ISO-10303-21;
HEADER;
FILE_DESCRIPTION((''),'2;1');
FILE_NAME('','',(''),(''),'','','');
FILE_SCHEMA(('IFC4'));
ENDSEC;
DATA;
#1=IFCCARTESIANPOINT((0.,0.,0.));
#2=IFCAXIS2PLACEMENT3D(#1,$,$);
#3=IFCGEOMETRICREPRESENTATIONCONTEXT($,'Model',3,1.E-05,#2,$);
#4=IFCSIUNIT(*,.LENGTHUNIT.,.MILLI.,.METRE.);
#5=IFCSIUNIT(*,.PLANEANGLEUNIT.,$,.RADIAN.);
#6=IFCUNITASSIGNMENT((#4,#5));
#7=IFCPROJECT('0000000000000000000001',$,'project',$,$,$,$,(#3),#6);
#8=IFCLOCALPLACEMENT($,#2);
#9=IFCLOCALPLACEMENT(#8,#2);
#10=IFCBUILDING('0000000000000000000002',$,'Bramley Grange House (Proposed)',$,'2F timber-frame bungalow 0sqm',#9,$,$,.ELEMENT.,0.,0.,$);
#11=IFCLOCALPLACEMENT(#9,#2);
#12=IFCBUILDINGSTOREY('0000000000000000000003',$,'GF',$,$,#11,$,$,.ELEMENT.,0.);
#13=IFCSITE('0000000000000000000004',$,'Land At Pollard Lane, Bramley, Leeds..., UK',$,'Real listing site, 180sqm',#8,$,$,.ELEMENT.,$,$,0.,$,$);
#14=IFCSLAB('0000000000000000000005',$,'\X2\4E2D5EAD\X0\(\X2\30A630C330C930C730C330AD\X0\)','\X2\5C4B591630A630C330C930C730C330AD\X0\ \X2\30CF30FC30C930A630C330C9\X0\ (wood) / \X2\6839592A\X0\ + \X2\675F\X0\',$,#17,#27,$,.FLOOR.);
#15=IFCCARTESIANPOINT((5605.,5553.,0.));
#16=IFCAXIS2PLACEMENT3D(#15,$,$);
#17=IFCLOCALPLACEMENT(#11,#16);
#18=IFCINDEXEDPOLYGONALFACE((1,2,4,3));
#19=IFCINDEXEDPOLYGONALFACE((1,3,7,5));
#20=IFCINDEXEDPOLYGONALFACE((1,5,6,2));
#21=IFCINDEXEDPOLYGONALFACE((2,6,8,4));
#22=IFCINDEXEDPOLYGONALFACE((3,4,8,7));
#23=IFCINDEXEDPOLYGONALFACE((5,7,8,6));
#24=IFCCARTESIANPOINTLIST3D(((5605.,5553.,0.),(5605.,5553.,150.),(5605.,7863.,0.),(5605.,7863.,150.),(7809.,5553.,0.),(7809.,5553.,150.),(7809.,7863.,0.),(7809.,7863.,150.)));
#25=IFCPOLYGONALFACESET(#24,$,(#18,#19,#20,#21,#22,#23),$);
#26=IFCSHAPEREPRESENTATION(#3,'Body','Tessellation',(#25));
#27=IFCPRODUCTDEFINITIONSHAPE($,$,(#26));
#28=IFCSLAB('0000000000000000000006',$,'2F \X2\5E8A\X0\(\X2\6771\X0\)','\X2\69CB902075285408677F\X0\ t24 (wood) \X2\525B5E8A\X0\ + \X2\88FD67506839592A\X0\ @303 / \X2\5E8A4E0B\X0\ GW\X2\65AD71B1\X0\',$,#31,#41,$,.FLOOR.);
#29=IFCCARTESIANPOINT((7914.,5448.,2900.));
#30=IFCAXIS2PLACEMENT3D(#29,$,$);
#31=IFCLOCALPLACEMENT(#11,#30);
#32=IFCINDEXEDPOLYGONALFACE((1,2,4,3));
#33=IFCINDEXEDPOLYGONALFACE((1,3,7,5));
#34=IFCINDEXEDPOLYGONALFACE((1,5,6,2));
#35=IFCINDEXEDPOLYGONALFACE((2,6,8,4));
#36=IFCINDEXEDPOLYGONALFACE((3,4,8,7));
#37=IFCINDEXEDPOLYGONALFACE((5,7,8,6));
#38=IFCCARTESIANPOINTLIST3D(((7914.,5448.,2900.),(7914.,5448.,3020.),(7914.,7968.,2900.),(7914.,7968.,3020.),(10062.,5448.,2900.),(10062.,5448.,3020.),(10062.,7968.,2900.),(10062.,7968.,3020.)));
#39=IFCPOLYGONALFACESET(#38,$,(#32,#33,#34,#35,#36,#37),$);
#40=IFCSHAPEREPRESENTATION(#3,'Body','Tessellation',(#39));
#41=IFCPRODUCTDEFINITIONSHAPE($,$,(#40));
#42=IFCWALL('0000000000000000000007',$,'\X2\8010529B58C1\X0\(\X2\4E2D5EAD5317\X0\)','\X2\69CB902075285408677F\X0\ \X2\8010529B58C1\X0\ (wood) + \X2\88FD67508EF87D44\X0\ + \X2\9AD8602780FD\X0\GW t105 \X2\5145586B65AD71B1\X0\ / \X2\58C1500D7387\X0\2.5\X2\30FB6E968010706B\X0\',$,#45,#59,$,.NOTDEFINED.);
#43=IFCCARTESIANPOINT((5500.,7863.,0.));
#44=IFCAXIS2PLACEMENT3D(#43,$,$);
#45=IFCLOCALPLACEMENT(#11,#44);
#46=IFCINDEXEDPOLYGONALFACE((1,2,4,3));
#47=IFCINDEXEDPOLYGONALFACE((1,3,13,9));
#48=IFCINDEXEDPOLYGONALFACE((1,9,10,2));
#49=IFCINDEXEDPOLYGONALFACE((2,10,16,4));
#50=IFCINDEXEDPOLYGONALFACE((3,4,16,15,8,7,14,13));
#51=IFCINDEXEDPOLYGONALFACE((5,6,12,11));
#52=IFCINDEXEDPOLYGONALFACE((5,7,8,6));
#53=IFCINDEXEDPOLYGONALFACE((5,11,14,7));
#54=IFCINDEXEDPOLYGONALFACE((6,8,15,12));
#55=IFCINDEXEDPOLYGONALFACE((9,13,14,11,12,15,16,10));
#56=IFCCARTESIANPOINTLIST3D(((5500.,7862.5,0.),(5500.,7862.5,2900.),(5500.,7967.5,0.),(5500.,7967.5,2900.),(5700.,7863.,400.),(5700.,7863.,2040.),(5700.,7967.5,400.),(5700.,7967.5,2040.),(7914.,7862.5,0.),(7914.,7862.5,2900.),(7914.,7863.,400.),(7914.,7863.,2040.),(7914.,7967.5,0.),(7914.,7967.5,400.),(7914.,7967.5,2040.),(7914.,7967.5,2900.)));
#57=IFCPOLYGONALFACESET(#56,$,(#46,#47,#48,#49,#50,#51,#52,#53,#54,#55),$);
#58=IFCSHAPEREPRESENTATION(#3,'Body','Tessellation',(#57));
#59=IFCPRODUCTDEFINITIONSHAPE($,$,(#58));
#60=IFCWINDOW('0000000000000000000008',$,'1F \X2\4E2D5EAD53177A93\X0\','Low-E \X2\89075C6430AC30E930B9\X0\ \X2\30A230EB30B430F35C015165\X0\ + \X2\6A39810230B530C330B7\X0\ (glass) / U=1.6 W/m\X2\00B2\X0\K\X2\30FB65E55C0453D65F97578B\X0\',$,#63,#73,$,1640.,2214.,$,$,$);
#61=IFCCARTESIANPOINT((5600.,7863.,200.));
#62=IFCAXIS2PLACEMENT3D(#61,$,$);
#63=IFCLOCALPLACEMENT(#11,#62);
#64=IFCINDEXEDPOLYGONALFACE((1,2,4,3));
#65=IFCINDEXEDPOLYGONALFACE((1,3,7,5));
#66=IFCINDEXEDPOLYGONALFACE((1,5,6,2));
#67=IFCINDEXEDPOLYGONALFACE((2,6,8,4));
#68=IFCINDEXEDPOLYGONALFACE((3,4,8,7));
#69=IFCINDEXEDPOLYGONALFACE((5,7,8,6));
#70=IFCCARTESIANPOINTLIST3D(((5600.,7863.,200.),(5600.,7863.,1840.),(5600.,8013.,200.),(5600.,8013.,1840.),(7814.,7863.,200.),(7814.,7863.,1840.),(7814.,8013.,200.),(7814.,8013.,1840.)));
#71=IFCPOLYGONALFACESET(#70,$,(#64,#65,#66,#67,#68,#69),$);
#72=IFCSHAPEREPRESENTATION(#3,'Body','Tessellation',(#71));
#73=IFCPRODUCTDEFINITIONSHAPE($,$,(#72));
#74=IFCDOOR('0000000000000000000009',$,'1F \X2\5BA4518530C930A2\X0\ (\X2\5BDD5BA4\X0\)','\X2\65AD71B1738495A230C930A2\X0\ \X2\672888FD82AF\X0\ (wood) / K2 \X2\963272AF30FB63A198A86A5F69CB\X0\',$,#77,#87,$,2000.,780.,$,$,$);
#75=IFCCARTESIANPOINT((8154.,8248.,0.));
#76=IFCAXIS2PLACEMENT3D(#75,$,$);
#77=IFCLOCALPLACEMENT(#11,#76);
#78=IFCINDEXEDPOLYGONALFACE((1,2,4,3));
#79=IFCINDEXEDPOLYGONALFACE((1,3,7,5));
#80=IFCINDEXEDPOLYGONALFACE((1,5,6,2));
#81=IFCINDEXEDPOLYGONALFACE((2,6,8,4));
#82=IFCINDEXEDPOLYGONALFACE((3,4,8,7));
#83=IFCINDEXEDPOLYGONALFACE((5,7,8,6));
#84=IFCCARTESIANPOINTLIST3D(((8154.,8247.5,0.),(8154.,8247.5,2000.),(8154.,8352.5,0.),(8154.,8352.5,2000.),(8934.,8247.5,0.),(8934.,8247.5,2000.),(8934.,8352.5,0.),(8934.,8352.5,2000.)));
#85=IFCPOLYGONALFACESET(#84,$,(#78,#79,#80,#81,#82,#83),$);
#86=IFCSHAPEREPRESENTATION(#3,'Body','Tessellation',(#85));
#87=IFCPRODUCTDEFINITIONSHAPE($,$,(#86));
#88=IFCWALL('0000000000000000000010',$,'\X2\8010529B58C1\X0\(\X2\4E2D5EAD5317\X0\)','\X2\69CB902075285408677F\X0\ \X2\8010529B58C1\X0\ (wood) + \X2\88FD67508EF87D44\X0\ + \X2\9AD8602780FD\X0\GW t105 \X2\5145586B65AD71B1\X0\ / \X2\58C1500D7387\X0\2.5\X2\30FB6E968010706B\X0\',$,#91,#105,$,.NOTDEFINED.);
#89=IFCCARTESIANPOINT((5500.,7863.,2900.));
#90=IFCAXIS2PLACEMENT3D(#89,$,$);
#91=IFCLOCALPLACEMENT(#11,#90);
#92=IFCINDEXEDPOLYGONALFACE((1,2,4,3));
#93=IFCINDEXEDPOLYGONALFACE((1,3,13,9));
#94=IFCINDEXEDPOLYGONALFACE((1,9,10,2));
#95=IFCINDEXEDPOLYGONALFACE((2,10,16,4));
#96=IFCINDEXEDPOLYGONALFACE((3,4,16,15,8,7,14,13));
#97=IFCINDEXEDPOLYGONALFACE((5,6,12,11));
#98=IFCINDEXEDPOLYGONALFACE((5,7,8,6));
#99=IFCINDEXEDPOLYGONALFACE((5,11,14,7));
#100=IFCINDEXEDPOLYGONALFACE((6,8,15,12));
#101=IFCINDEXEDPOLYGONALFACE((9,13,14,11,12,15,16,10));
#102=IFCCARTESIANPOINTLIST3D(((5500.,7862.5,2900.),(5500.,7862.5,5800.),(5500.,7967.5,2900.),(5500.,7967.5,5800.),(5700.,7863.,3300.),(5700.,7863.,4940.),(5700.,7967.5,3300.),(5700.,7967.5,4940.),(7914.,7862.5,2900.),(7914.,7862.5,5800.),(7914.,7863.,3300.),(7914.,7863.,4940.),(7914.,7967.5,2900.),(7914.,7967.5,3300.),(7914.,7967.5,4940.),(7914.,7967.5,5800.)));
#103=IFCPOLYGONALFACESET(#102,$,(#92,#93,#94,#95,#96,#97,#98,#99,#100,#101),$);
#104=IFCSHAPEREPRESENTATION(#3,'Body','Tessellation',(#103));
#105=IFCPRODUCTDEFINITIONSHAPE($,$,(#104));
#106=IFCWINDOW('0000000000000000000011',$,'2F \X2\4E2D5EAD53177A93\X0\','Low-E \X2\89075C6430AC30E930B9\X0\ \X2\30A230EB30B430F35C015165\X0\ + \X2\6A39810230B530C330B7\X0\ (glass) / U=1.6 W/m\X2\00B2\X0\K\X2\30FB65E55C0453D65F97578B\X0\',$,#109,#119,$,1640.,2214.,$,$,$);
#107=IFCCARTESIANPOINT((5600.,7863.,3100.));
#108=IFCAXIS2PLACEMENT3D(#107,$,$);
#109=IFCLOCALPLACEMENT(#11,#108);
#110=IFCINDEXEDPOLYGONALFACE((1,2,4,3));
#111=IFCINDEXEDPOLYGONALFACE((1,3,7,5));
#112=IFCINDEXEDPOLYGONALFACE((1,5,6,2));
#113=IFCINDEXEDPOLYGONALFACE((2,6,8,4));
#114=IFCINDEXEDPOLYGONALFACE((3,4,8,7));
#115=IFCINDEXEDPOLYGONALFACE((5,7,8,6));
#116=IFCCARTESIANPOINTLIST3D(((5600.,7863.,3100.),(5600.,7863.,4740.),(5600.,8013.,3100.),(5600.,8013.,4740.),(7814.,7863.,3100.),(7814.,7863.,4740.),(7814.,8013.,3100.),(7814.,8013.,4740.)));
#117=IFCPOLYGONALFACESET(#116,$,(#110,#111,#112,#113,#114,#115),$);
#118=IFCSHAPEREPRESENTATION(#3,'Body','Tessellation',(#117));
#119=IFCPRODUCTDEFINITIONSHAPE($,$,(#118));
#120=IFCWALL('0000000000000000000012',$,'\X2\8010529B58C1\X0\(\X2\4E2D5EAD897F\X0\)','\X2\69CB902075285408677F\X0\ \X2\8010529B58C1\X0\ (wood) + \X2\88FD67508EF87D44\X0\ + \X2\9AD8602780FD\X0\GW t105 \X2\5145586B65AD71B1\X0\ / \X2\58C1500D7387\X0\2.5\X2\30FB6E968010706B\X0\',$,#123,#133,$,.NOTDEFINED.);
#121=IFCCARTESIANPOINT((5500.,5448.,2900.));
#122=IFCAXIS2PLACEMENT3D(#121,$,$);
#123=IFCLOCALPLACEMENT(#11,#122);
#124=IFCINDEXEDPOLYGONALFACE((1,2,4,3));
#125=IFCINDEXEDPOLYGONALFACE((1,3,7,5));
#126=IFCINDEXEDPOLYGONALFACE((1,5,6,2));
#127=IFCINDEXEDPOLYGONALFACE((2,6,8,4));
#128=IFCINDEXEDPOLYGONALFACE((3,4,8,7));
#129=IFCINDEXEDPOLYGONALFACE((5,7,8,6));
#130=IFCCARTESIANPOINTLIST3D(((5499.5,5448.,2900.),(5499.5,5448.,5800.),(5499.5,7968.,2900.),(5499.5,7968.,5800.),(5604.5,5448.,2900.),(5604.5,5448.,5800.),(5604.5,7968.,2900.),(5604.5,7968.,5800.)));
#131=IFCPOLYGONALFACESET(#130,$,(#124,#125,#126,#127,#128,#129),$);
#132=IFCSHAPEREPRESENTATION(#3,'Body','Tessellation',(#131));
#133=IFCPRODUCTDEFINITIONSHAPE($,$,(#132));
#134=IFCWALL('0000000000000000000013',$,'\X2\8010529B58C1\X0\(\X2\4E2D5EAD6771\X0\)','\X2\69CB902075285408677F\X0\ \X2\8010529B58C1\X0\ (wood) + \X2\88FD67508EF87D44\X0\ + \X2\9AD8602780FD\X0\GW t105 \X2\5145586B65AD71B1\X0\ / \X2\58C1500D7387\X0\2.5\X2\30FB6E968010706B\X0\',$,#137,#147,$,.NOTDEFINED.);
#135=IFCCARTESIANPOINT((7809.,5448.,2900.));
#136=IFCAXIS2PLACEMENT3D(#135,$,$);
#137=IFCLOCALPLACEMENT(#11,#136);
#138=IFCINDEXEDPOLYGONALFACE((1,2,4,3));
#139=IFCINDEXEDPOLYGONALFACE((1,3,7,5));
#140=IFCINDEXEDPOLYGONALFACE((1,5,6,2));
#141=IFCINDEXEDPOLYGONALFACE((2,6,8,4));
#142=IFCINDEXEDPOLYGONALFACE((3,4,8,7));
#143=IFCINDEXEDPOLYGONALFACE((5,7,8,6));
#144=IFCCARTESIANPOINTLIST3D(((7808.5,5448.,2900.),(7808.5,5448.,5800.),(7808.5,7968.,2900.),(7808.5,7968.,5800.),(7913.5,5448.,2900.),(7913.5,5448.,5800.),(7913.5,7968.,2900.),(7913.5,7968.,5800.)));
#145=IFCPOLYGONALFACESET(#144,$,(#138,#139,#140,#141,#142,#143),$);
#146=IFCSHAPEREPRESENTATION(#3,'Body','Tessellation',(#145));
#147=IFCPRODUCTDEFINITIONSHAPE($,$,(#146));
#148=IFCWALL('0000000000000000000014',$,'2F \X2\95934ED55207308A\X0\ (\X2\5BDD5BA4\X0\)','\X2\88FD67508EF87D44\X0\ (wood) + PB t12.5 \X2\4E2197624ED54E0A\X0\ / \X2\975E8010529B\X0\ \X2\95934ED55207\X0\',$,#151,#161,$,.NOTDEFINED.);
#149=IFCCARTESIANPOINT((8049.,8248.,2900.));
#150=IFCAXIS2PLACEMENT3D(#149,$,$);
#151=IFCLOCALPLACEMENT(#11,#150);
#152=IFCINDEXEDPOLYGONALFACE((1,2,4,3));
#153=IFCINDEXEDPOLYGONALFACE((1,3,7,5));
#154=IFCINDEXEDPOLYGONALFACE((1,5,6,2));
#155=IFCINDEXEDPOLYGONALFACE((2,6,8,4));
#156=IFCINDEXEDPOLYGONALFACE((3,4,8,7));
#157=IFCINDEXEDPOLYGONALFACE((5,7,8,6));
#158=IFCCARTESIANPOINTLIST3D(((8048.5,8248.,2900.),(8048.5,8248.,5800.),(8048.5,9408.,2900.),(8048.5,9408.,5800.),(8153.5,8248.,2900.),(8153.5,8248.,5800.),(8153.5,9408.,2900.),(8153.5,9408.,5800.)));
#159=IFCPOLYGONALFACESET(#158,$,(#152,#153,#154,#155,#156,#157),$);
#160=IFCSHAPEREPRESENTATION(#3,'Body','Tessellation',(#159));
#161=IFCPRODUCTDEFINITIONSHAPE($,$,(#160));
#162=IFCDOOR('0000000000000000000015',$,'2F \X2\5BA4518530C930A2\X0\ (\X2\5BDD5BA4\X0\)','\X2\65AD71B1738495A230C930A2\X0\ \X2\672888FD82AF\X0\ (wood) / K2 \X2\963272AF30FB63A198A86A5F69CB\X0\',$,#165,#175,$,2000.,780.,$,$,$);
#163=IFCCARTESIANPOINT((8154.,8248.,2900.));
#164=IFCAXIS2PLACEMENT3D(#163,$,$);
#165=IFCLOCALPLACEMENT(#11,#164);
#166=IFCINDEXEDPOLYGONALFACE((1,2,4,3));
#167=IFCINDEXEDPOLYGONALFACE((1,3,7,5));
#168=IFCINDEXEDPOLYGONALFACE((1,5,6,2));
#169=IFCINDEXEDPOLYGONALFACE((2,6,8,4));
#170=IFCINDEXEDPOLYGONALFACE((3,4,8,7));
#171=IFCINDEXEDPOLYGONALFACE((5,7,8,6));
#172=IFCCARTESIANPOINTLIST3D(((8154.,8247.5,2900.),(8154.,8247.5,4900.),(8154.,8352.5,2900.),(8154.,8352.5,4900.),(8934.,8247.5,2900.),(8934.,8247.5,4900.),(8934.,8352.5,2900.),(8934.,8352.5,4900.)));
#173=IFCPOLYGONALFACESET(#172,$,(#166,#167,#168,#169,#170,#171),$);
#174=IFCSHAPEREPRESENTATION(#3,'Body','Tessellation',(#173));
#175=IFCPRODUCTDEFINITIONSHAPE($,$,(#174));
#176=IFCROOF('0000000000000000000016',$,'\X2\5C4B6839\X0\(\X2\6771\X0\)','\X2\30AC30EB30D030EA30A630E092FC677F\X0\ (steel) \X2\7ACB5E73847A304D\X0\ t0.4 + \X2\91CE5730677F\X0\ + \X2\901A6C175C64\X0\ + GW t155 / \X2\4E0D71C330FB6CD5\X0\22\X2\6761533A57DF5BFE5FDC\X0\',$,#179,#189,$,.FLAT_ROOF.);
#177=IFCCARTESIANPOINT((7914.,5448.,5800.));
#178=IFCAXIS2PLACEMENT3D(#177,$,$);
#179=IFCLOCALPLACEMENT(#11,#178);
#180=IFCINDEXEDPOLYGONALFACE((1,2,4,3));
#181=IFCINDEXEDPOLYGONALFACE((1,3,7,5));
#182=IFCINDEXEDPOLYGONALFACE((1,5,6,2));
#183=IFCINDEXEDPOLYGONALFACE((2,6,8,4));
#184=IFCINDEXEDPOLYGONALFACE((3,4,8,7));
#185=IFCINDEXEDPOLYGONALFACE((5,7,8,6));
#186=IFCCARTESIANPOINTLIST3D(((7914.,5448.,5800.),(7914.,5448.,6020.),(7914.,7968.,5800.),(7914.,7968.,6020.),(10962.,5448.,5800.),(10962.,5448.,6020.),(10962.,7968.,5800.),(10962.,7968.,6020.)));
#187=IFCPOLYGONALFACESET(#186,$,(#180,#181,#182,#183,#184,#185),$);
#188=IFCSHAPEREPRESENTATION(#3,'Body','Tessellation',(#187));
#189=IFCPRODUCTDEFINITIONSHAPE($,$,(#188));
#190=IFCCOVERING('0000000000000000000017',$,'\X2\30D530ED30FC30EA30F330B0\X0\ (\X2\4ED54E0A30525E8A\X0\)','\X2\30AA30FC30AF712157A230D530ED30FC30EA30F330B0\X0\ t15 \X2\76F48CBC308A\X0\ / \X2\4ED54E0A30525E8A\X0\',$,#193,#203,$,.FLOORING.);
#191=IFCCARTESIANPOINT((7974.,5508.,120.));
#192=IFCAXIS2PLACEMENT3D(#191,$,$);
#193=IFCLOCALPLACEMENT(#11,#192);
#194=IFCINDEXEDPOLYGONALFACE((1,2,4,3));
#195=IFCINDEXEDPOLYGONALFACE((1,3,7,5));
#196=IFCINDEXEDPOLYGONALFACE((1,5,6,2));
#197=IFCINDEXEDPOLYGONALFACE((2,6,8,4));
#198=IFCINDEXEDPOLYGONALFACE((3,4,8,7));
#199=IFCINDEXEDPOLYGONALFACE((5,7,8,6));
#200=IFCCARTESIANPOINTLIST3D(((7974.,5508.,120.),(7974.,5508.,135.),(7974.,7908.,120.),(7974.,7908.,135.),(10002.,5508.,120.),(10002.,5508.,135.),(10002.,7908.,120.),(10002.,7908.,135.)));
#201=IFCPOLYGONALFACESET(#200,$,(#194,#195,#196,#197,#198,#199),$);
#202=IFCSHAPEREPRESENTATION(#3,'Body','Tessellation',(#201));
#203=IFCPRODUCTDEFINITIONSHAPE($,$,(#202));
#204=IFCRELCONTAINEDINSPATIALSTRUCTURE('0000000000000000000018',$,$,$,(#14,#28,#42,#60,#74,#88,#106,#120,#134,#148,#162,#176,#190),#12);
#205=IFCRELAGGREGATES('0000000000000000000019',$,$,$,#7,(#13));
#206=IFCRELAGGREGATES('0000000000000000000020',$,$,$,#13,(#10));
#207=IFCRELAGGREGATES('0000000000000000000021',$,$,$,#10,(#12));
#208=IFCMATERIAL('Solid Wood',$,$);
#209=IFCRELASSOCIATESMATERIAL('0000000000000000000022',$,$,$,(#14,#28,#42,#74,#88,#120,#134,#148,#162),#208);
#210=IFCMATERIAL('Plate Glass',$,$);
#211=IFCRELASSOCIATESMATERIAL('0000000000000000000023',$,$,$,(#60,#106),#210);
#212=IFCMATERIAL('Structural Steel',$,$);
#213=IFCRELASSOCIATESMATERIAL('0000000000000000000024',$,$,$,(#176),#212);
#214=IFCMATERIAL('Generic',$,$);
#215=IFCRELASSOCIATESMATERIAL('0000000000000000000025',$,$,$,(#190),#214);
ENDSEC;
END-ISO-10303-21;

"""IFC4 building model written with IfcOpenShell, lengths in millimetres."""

from ifc_helpers import new_model, si_unit, frame, frame_2d, origin, place, context, project, spatial, rectangle, extrude, material, element, fill, save


model = new_model("IFC4")

# Units and contexts
model_context = context("Model", 3, precision=1e-05, world=origin())
ifc_project = project(units=[si_unit("LENGTHUNIT", "METRE", prefix="MILLI"), si_unit("PLANEANGLEUNIT", "RADIAN")], contexts=[model_context])

# Site, building, storey
site_placement = place(None, origin())
site = spatial("IfcSite", under=ifc_project, at=site_placement, Name="Land At Pollard Lane, Bramley, Leeds..., UK", ObjectType="Real listing site, 180sqm", CompositionType="ELEMENT", RefElevation=0.0)
building_placement = place(site_placement, origin())
building = spatial("IfcBuilding", under=site, at=building_placement, Name="Bramley Grange House (Proposed)", ObjectType="2F timber-frame bungalow 0sqm", CompositionType="ELEMENT", ElevationOfRefHeight=0.0, ElevationOfTerrain=0.0)
storey_placement = place(building_placement, origin())
storey = spatial("IfcBuildingStorey", under=building, at=storey_placement, Name="GF", CompositionType="ELEMENT", Elevation=0.0)

# Slabs
ifc_material_1 = material(Name="Solid Wood")
slab_1_placement = place(storey_placement, frame((5605.0, 5553.0, 0.0)))
element("IfcSlab", 1, at=slab_1_placement, inside=storey, material=ifc_material_1, Name="中庭(ウッドデッキ)", Description="屋外ウッドデッキ ハードウッド (wood) / 根太 + 束", PredefinedType="FLOOR", context=model_context, shape_type="SweptSolid", body=[
    extrude(rectangle(XDim=2204.0, YDim=2310.0, at=frame_2d((1102.0, 1155.0))), frame((5605.0, 5553.0, 0.0)), (0.0, 0.0, 1.0), 150.0),
])
slab_2_placement = place(storey_placement, frame((7914.0, 5448.0, 2900.0)))
element("IfcSlab", 2, at=slab_2_placement, inside=storey, material=ifc_material_1, Name="2F 床(東)", Description="構造用合板 t24 (wood) 剛床 + 製材根太 @303 / 床下 GW断熱", PredefinedType="FLOOR", context=model_context, shape_type="SweptSolid", body=[
    extrude(rectangle(XDim=2148.0, YDim=2520.0, at=frame_2d((1074.0, 1260.0))), frame((7914.0, 5448.0, 2900.0)), (0.0, 0.0, 1.0), 120.0),
])

# Wall, opening, window
wall_1_placement = place(storey_placement, frame((5500.0, 7863.0, 0.0)))
wall_1 = element("IfcWall", 3, at=wall_1_placement, inside=storey, material=ifc_material_1, Name="耐力壁(中庭北)", Description="構造用合板 耐力壁 (wood) + 製材軸組 + 高性能GW t105 充填断熱 / 壁倍率2.5・準耐火", PredefinedType="NOTDEFINED", context=model_context, shape_type="SweptSolid", body=[
    extrude(rectangle(XDim=2414.0, YDim=105.0, at=frame_2d((1207.0, 52.0))), frame((5500.0, 7863.0, 0.0)), (0.0, 0.0, 1.0), 2900.0),
])
opening_1_placement = place(storey_placement, frame((5600.0, 7863.0, 200.0)))
opening_1 = element("IfcOpeningElement", 4, at=opening_1_placement, cuts=wall_1, PredefinedType="NOTDEFINED", context=model_context, shape_type="SweptSolid", body=[
    extrude(rectangle(XDim=2214.0, YDim=150.0, at=frame_2d((1107.0, 75.0))), frame((5600.0, 7863.0, 200.0)), (0.0, 0.0, 1.0), 1640.0),
])
ifc_material_2 = material(Name="Plate Glass")
window_1_placement = place(storey_placement, frame((5600.0, 7863.0, 200.0)))
window_1 = element("IfcWindow", 5, at=window_1_placement, inside=storey, material=ifc_material_2, Name="1F 中庭北窓", Description="Low-E 複層ガラス アルゴン封入 + 樹脂サッシ (glass) / U=1.6 W/m²K・日射取得型", OverallHeight=1640.0, OverallWidth=2214.0, context=model_context, shape_type="SweptSolid", body=[
    extrude(rectangle(XDim=2214.0, YDim=150.0, at=frame_2d((1107.0, 75.0))), frame((5600.0, 7863.0, 200.0)), (0.0, 0.0, 1.0), 1640.0),
])
fill(opening_1, window_1)

# Door
door_1_placement = place(storey_placement, frame((8154.0, 8248.0, 0.0)))
element("IfcDoor", 6, at=door_1_placement, inside=storey, material=ifc_material_1, Name="1F 室内ドア (寝室)", Description="断熱玄関ドア 木製芯 (wood) / K2 防犯・採風機構", OverallHeight=2000.0, OverallWidth=780.0, context=model_context, shape_type="SweptSolid", body=[
    extrude(rectangle(XDim=780.0, YDim=105.0, at=frame_2d((390.0, 52.0))), frame((8154.0, 8248.0, 0.0)), (0.0, 0.0, 1.0), 2000.0),
])

# Wall, opening, window
wall_2_placement = place(storey_placement, frame((5500.0, 7863.0, 2900.0)))
wall_2 = element("IfcWall", 7, at=wall_2_placement, inside=storey, material=ifc_material_1, Name="耐力壁(中庭北)", Description="構造用合板 耐力壁 (wood) + 製材軸組 + 高性能GW t105 充填断熱 / 壁倍率2.5・準耐火", PredefinedType="NOTDEFINED", context=model_context, shape_type="SweptSolid", body=[
    extrude(rectangle(XDim=2414.0, YDim=105.0, at=frame_2d((1207.0, 52.0))), frame((5500.0, 7863.0, 2900.0)), (0.0, 0.0, 1.0), 2900.0),
])
opening_2_placement = place(storey_placement, frame((5600.0, 7863.0, 3100.0)))
opening_2 = element("IfcOpeningElement", 8, at=opening_2_placement, cuts=wall_2, PredefinedType="NOTDEFINED", context=model_context, shape_type="SweptSolid", body=[
    extrude(rectangle(XDim=2214.0, YDim=150.0, at=frame_2d((1107.0, 75.0))), frame((5600.0, 7863.0, 3100.0)), (0.0, 0.0, 1.0), 1640.0),
])
window_2_placement = place(storey_placement, frame((5600.0, 7863.0, 3100.0)))
window_2 = element("IfcWindow", 9, at=window_2_placement, inside=storey, material=ifc_material_2, Name="2F 中庭北窓", Description="Low-E 複層ガラス アルゴン封入 + 樹脂サッシ (glass) / U=1.6 W/m²K・日射取得型", OverallHeight=1640.0, OverallWidth=2214.0, context=model_context, shape_type="SweptSolid", body=[
    extrude(rectangle(XDim=2214.0, YDim=150.0, at=frame_2d((1107.0, 75.0))), frame((5600.0, 7863.0, 3100.0)), (0.0, 0.0, 1.0), 1640.0),
])
fill(opening_2, window_2)

# Walls
wall_3_placement = place(storey_placement, frame((5500.0, 5448.0, 2900.0)))
element("IfcWall", 10, at=wall_3_placement, inside=storey, material=ifc_material_1, Name="耐力壁(中庭西)", Description="構造用合板 耐力壁 (wood) + 製材軸組 + 高性能GW t105 充填断熱 / 壁倍率2.5・準耐火", PredefinedType="NOTDEFINED", context=model_context, shape_type="SweptSolid", body=[
    extrude(rectangle(XDim=105.0, YDim=2520.0, at=frame_2d((52.0, 1260.0))), frame((5500.0, 5448.0, 2900.0)), (0.0, 0.0, 1.0), 2900.0),
])
wall_4_placement = place(storey_placement, frame((7809.0, 5448.0, 2900.0)))
element("IfcWall", 11, at=wall_4_placement, inside=storey, material=ifc_material_1, Name="耐力壁(中庭東)", Description="構造用合板 耐力壁 (wood) + 製材軸組 + 高性能GW t105 充填断熱 / 壁倍率2.5・準耐火", PredefinedType="NOTDEFINED", context=model_context, shape_type="SweptSolid", body=[
    extrude(rectangle(XDim=105.0, YDim=2520.0, at=frame_2d((52.0, 1260.0))), frame((7809.0, 5448.0, 2900.0)), (0.0, 0.0, 1.0), 2900.0),
])
wall_5_placement = place(storey_placement, frame((8049.0, 8248.0, 2900.0)))
element("IfcWall", 12, at=wall_5_placement, inside=storey, material=ifc_material_1, Name="2F 間仕切り (寝室)", Description="製材軸組 (wood) + PB t12.5 両面仕上 / 非耐力 間仕切", PredefinedType="NOTDEFINED", context=model_context, shape_type="SweptSolid", body=[
    extrude(rectangle(XDim=105.0, YDim=1160.0, at=frame_2d((52.0, 580.0))), frame((8049.0, 8248.0, 2900.0)), (0.0, 0.0, 1.0), 2900.0),
])

# Door
door_2_placement = place(storey_placement, frame((8154.0, 8248.0, 2900.0)))
element("IfcDoor", 13, at=door_2_placement, inside=storey, material=ifc_material_1, Name="2F 室内ドア (寝室)", Description="断熱玄関ドア 木製芯 (wood) / K2 防犯・採風機構", OverallHeight=2000.0, OverallWidth=780.0, context=model_context, shape_type="SweptSolid", body=[
    extrude(rectangle(XDim=780.0, YDim=105.0, at=frame_2d((390.0, 52.0))), frame((8154.0, 8248.0, 2900.0)), (0.0, 0.0, 1.0), 2000.0),
])

# Roof
ifc_material_3 = material(Name="Structural Steel")
roof_placement = place(storey_placement, frame((7914.0, 5448.0, 5800.0)))
element("IfcRoof", 14, at=roof_placement, inside=storey, material=ifc_material_3, Name="屋根(東)", Description="ガルバリウム鋼板 (steel) 立平葺き t0.4 + 野地板 + 通気層 + GW t155 / 不燃・法22条区域対応", PredefinedType="FLAT_ROOF", context=model_context, shape_type="SweptSolid", body=[
    extrude(rectangle(XDim=3048.0, YDim=2520.0, at=frame_2d((1524.0, 1260.0))), frame((7914.0, 5448.0, 5800.0)), (0.0, 0.0, 1.0), 220.0),
])

# Covering
ifc_material_4 = material(Name="Generic")
covering_1_placement = place(storey_placement, frame((7974.0, 5508.0, 120.0)))
element("IfcCovering", 15, at=covering_1_placement, inside=storey, material=ifc_material_4, Name="フローリング (仕上げ床)", Description="オーク無垢フローリング t15 直貼り / 仕上げ床", PredefinedType="FLOORING", context=model_context, shape_type="SweptSolid", body=[
    extrude(rectangle(XDim=2028.0, YDim=2400.0, at=frame_2d((1014.0, 1200.0))), frame((7974.0, 5508.0, 120.0)), (0.0, 0.0, 1.0), 15.0),
])

save(model, "model.ifc")
